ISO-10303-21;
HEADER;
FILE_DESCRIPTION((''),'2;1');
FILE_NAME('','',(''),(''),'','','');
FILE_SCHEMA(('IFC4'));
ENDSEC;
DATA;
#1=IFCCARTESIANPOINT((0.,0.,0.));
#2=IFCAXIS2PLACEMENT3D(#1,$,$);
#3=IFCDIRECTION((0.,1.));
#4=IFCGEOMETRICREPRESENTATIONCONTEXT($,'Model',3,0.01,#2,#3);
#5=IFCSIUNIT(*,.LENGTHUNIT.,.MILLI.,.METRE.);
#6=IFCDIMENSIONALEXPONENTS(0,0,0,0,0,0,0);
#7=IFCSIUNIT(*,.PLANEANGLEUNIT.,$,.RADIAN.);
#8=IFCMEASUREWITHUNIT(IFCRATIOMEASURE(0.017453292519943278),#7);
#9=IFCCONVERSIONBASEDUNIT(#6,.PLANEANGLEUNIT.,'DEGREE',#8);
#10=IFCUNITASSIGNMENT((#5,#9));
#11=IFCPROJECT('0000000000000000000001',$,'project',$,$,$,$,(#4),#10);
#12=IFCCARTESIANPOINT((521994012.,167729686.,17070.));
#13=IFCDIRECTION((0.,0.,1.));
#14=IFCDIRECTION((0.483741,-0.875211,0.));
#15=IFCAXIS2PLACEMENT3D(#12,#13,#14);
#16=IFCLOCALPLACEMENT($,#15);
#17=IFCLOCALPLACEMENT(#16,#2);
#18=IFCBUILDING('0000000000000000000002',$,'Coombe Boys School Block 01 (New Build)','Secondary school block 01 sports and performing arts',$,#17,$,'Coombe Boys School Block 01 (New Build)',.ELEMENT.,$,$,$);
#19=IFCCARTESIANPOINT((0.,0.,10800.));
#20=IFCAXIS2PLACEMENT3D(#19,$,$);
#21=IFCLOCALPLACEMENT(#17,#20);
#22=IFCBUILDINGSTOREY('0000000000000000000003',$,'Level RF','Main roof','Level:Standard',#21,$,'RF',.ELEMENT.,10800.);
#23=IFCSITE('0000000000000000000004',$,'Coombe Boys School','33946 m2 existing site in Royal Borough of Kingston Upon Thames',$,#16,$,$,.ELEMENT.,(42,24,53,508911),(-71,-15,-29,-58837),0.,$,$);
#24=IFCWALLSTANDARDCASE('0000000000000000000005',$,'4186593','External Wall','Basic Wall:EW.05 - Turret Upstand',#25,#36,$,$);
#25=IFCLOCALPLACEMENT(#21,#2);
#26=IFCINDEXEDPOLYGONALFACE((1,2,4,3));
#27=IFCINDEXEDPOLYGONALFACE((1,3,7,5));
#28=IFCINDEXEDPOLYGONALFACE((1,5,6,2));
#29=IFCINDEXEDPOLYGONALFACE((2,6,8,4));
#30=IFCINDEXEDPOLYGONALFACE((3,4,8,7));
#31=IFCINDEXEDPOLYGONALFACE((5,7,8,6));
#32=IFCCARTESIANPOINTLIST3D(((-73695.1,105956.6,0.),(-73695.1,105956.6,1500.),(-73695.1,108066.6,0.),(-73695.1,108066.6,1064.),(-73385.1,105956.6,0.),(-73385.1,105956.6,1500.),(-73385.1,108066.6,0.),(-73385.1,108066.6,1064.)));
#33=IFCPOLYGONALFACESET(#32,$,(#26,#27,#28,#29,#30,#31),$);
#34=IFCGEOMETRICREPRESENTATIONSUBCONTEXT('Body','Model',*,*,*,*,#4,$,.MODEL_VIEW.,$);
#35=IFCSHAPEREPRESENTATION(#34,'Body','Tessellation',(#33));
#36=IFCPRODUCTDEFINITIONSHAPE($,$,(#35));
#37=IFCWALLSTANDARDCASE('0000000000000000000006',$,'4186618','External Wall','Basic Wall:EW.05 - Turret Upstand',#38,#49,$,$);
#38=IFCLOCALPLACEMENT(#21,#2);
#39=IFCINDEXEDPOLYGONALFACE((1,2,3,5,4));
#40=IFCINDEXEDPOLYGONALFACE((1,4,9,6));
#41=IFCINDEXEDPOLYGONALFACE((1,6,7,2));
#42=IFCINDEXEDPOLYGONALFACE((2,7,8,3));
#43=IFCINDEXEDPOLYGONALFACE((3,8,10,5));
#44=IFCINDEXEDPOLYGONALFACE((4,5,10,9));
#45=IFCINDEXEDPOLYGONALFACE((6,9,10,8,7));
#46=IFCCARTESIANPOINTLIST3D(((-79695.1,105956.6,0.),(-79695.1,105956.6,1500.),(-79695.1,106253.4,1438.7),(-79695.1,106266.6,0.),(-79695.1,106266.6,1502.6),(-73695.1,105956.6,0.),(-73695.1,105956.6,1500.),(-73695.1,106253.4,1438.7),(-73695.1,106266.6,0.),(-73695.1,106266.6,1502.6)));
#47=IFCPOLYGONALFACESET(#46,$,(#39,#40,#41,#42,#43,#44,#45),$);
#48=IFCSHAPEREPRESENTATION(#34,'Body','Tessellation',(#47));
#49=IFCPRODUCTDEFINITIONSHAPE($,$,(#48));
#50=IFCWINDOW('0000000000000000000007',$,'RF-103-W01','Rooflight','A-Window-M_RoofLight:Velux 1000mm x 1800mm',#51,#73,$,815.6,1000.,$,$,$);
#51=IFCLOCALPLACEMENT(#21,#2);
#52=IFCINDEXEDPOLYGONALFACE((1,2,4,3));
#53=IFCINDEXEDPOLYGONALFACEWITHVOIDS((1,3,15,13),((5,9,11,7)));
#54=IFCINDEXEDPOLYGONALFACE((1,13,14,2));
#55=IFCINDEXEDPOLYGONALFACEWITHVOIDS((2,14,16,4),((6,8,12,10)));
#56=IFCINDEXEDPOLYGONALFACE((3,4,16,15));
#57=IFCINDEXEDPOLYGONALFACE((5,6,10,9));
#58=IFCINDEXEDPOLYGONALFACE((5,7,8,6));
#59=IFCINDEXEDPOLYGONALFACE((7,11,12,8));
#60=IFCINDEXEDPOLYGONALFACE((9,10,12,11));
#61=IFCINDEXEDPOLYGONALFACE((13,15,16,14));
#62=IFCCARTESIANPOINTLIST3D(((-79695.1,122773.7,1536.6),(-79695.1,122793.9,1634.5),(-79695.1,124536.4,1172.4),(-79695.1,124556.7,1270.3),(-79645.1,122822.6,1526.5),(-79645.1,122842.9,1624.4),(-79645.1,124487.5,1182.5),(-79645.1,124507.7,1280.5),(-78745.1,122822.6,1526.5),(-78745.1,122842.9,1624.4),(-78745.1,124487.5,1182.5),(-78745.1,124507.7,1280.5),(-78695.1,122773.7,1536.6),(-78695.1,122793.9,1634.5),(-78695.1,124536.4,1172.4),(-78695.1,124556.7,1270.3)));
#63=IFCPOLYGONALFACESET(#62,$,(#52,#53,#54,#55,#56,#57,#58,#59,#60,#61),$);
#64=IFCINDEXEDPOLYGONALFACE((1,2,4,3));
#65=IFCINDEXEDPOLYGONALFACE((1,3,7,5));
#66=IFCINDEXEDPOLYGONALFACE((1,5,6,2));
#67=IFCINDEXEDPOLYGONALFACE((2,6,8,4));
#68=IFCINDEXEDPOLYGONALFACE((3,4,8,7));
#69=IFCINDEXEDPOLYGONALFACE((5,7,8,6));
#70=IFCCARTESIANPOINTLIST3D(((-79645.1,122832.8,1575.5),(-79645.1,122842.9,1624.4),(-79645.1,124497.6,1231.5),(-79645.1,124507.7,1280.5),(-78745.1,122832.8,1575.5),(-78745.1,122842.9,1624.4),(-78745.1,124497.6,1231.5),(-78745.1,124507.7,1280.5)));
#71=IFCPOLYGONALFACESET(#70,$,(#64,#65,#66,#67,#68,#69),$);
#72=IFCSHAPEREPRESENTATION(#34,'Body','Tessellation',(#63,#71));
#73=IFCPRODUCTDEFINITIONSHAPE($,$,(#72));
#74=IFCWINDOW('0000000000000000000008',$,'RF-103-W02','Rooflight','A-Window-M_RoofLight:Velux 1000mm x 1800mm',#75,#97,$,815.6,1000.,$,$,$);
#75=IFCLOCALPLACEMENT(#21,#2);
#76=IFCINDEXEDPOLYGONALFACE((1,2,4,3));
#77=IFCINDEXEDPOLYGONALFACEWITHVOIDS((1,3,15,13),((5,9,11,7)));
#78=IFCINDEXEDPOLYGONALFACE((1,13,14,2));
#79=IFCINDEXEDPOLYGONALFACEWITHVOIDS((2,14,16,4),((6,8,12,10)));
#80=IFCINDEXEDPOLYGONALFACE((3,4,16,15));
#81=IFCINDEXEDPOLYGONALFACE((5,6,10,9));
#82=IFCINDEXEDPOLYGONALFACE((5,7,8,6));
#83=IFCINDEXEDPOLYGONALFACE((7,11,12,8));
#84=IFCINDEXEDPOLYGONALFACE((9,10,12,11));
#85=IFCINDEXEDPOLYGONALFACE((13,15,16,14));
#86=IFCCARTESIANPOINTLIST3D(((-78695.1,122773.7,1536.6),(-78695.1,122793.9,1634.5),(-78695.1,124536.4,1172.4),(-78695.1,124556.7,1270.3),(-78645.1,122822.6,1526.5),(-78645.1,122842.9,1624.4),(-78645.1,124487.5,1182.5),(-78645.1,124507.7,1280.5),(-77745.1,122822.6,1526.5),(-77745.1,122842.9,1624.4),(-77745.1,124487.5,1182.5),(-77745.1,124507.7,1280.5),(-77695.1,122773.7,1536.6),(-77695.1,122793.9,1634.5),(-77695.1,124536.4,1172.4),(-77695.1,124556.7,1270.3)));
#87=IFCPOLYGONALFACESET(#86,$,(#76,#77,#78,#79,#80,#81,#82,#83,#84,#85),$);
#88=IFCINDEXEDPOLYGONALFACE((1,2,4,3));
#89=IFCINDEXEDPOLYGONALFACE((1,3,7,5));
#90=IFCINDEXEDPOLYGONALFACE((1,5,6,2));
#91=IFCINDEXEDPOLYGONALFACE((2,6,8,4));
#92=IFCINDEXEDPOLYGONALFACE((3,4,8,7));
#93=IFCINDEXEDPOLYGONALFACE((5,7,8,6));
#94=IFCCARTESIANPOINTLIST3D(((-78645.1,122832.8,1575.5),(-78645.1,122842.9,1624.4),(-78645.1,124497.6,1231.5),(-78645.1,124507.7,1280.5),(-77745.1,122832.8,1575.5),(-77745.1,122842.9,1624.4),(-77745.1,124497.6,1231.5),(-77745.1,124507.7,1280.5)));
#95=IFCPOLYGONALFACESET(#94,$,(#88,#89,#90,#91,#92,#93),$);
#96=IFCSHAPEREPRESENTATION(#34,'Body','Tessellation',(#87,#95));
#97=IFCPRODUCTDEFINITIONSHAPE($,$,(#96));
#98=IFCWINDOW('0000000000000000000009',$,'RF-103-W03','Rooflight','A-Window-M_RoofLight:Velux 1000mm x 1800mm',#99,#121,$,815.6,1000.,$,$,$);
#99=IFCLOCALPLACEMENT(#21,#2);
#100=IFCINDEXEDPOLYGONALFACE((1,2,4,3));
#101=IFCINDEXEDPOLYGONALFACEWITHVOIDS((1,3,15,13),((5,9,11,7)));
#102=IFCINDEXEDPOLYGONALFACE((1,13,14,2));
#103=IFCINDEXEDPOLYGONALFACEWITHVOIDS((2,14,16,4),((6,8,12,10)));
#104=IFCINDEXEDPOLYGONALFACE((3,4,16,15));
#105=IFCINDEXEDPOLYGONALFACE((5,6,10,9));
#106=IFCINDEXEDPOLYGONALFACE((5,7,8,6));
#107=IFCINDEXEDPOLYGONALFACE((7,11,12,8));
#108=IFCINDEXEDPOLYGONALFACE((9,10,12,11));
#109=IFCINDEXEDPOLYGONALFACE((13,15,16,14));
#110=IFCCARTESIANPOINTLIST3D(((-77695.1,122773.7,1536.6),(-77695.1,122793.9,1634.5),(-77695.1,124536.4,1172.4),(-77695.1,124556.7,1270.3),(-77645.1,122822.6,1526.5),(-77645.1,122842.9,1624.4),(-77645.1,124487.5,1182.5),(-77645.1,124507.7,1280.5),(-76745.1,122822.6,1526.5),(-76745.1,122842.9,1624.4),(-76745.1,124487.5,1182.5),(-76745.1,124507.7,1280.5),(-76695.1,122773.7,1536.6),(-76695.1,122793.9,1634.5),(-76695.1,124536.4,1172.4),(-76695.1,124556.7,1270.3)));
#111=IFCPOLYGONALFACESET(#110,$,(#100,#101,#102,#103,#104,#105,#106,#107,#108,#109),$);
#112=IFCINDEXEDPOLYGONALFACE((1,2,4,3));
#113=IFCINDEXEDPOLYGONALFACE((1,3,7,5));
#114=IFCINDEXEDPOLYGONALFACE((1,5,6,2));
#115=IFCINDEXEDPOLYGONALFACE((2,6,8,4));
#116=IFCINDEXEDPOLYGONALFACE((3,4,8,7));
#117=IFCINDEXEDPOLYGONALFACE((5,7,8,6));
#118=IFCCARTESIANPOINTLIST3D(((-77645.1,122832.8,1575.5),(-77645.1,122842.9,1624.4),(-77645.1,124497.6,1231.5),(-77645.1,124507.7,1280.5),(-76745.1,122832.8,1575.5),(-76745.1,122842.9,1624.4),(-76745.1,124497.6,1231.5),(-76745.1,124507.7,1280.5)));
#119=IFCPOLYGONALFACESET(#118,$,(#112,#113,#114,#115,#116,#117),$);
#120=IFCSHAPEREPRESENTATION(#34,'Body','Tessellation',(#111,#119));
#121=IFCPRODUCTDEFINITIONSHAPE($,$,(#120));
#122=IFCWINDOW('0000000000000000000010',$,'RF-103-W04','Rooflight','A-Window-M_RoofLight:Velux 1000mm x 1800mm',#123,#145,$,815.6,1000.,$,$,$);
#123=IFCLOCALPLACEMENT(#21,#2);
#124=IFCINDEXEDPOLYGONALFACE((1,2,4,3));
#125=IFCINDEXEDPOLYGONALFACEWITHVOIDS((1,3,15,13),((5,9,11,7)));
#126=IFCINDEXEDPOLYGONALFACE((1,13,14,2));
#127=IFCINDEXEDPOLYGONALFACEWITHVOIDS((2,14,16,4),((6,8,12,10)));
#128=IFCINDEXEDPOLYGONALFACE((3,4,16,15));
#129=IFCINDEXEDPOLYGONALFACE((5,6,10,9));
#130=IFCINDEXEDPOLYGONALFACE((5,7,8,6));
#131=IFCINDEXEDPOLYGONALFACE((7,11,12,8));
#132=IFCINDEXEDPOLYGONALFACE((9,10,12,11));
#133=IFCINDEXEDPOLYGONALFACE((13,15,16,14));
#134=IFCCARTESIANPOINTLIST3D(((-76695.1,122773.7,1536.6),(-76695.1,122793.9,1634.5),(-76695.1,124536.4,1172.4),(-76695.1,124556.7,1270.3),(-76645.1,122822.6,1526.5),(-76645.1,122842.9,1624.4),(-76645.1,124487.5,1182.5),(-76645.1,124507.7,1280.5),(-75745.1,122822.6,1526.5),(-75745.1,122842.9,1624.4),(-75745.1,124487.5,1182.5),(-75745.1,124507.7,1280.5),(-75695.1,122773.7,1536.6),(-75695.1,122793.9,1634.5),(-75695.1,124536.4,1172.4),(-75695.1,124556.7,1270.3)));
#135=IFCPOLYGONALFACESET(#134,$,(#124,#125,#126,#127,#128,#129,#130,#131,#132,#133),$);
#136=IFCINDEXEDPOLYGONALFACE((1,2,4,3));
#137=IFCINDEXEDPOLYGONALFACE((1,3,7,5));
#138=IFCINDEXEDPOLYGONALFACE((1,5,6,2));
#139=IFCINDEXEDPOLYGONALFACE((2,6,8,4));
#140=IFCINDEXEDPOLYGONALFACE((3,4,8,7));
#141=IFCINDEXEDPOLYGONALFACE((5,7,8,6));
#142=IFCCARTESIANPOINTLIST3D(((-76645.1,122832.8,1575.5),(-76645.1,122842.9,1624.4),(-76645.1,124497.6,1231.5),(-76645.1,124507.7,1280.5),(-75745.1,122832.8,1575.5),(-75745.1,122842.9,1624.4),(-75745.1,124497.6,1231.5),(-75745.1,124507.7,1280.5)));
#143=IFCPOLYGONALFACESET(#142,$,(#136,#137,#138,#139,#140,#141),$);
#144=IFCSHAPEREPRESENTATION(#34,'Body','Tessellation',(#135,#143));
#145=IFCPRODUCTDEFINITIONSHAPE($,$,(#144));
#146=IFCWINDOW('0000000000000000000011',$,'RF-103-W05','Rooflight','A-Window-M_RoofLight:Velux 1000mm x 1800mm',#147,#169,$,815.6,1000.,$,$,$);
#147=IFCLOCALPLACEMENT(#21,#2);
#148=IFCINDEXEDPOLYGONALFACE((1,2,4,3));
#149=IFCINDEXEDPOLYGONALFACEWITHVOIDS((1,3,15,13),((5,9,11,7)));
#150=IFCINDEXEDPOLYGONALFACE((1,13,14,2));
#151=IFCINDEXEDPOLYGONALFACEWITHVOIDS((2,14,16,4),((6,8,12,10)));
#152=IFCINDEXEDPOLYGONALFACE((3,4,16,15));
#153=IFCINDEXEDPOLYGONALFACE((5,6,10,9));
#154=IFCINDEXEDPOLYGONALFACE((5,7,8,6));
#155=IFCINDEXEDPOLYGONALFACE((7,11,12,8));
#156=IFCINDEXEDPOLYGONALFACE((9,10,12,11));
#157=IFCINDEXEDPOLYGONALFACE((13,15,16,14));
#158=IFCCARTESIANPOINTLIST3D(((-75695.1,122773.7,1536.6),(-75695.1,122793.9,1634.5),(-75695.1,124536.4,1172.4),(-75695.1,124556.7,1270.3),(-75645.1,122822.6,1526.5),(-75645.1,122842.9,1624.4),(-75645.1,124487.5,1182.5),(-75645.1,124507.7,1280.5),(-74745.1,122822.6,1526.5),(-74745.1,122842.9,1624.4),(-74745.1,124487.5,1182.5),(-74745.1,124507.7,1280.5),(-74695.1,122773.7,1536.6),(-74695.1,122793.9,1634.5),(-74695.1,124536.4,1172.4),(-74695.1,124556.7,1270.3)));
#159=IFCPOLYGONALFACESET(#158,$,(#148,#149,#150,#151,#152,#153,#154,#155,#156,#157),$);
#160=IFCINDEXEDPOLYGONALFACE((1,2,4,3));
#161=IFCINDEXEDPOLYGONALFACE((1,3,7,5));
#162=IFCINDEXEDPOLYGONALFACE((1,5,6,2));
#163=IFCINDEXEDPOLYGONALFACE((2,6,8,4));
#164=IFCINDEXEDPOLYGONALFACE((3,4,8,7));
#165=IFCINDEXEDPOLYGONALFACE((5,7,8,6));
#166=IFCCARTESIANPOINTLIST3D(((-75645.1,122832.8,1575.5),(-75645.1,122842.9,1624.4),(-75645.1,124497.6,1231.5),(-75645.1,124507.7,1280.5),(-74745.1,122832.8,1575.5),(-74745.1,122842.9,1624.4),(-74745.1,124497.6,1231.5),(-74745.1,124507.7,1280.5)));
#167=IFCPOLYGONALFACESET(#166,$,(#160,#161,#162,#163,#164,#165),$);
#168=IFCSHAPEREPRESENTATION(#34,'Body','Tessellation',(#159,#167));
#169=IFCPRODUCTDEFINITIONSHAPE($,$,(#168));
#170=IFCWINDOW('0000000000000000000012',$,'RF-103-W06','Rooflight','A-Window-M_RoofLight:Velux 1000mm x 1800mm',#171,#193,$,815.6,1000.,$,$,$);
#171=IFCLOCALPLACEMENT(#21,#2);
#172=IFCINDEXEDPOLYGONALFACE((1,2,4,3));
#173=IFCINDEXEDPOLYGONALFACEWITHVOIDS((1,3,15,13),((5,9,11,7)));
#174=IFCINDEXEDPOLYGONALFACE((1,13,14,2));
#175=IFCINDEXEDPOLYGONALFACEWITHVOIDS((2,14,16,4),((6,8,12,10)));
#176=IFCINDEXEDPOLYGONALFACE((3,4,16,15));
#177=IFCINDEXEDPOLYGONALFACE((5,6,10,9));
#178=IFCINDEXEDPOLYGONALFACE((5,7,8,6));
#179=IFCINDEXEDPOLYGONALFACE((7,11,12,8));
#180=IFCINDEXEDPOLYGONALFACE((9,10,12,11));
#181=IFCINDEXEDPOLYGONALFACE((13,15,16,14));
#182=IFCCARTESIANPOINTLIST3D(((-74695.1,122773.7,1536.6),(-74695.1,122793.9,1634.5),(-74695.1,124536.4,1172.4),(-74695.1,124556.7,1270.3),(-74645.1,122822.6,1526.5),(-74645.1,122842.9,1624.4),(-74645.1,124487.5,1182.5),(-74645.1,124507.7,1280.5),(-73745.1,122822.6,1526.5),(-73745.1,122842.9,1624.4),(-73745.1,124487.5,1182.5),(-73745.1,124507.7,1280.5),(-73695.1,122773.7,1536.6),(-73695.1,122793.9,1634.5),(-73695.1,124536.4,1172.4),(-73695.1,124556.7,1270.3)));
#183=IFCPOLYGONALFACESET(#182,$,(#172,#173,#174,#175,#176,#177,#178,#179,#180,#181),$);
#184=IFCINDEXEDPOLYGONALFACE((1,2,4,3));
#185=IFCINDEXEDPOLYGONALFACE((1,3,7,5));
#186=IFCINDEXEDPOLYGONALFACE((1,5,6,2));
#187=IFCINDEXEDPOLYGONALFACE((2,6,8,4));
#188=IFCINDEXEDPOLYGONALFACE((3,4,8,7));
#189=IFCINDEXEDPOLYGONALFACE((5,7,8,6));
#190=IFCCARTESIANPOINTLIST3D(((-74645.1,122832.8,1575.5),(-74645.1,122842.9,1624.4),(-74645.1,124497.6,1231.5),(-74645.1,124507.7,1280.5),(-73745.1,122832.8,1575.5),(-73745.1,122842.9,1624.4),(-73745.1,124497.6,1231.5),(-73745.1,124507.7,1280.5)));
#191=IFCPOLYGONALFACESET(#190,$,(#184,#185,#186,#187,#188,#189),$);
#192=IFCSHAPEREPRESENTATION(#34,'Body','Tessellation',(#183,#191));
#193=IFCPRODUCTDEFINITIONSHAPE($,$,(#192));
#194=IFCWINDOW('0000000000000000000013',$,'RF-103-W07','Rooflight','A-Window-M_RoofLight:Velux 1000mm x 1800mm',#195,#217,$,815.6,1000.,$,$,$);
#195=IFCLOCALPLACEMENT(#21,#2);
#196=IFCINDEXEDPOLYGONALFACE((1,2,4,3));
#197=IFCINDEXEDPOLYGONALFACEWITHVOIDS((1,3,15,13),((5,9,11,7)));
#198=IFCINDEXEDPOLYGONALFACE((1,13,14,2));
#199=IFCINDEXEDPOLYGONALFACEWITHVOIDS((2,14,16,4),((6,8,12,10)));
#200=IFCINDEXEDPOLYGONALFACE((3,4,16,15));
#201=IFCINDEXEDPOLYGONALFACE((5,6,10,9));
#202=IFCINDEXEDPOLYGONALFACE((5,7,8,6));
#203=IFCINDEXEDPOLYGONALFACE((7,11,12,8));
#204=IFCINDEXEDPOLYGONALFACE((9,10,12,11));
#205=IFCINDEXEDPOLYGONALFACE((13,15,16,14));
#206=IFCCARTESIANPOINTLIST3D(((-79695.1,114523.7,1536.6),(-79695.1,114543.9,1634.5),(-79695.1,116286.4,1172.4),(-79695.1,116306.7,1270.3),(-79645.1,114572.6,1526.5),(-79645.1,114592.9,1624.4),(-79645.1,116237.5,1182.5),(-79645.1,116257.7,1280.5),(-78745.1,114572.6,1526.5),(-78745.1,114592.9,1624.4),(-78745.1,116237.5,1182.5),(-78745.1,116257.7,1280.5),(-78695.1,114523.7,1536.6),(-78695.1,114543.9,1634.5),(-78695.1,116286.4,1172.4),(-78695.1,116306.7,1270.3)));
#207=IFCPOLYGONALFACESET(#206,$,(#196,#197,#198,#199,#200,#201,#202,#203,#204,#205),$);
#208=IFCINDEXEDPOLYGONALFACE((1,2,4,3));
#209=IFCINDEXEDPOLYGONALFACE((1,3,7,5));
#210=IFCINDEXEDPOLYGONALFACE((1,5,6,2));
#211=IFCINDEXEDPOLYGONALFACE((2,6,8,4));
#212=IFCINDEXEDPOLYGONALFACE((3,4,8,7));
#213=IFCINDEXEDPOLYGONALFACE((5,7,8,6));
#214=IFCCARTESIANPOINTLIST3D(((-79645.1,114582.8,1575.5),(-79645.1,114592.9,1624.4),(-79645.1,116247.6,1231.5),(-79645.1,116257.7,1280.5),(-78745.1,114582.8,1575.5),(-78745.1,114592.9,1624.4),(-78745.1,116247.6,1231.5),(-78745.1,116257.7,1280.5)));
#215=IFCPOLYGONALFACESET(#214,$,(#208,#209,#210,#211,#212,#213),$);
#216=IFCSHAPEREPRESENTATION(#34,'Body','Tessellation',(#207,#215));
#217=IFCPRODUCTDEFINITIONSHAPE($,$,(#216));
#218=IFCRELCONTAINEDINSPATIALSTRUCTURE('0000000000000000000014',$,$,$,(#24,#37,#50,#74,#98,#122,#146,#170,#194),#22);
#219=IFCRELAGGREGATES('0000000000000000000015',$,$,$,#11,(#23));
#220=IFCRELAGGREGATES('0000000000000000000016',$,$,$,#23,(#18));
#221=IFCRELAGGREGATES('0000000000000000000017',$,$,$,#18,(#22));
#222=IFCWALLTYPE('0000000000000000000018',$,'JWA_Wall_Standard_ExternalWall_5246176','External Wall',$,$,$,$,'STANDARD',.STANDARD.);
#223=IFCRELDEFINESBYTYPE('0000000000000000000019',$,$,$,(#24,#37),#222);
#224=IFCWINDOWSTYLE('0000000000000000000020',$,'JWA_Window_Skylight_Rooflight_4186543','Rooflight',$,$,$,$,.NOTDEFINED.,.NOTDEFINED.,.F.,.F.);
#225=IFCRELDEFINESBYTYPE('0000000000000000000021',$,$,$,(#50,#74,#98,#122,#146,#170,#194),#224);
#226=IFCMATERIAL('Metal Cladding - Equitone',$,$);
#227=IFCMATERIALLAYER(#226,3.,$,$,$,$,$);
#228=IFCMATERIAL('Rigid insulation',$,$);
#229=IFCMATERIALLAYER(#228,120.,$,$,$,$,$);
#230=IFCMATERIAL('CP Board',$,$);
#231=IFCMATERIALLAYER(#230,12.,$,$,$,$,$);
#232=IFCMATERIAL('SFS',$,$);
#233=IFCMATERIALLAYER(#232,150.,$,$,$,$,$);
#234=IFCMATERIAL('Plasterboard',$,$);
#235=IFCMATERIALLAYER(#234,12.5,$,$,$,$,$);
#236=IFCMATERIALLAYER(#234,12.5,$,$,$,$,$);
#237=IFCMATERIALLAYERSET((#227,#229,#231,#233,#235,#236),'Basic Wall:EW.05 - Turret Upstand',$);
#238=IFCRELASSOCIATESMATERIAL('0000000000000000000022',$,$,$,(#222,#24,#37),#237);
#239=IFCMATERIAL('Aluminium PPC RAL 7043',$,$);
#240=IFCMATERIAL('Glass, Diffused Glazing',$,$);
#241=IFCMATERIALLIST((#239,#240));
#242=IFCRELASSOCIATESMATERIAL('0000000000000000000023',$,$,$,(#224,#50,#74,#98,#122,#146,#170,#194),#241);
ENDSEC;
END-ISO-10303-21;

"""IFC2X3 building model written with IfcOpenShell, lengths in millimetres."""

from ifc_helpers import new_model, entity, si_unit, converted_unit, direction, frame, frame_2d, origin, place, context, subcontext, project, spatial, polyline, rectangle, outline, extrude, clip, bounded_halfspace, source, transform, mapped, material, material_list, layer, layer_set, layer_usage, type_object, type_shapes, element, save


model = new_model("IFC2X3")

# Units and contexts
model_context = context("Model", 3, precision=0.01, world=origin(), true_north=direction((0.0, 1.0)))
body_context = subcontext(model_context, "Body", "Model", "MODEL_VIEW")
ifc_project = project(units=[si_unit("LENGTHUNIT", "METRE", prefix="MILLI"), converted_unit("PLANEANGLEUNIT", "DEGREE", entity("IfcRatioMeasure", 0.017453292519943278), si_unit("PLANEANGLEUNIT", "RADIAN"), dimensions=[0, 0, 0, 0, 0, 0, 0])], contexts=[model_context])

# Site, building, storey
site_placement = place(None, frame((521994012.0, 167729686.0, 17070.0), z_axis=(0.0, 0.0, 1.0), x_axis=(0.483741, -0.875211, 0.0)))
site = spatial("IfcSite", under=ifc_project, at=site_placement, Name="Coombe Boys School", Description="33946 m2 existing site in Royal Borough of Kingston Upon Thames", CompositionType="ELEMENT", RefLatitude=(42, 24, 53, 508911), RefLongitude=(-71, -15, -29, -58837), RefElevation=0.0)
building_placement = place(site_placement, origin())
building = spatial("IfcBuilding", under=site, at=building_placement, Name="Coombe Boys School Block 01 (New Build)", Description="Secondary school block 01 sports and performing arts", LongName="Coombe Boys School Block 01 (New Build)", CompositionType="ELEMENT")
storey_placement = place(building_placement, frame((0.0, 0.0, 10800.0)))
storey = spatial("IfcBuildingStorey", under=building, at=storey_placement, Name="Level RF", Description="Main roof", ObjectType="Level:Standard", LongName="RF", CompositionType="ELEMENT", Elevation=10800.0)

# Walls
ifc_material_1 = material(Name="Metal Cladding - Equitone")
ifc_layer_1 = layer(ifc_material_1, 3.0)
ifc_material_2 = material(Name="Rigid insulation")
ifc_layer_2 = layer(ifc_material_2, 120.0)
ifc_material_3 = material(Name="CP Board")
ifc_layer_3 = layer(ifc_material_3, 12.0)
ifc_material_4 = material(Name="SFS")
ifc_layer_4 = layer(ifc_material_4, 150.0)
ifc_material_5 = material(Name="Plasterboard")
ifc_layer_5 = layer(ifc_material_5, 12.5)
ifc_layer_6 = layer(ifc_material_5, 12.5)
ifc_layer_set_1 = layer_set([ifc_layer_1, ifc_layer_2, ifc_layer_3, ifc_layer_4, ifc_layer_5, ifc_layer_6], Name="Basic Wall:EW.05 - Turret Upstand")
ifc_layer_usage_1 = layer_usage(ifc_layer_set_1, "AXIS2", "POSITIVE", -155.0)
wall_type_1 = type_object("IfcWallType", Name="JWA_Wall_Standard_ExternalWall_5246176", Description="External Wall", ElementType="STANDARD", PredefinedType="STANDARD", material=ifc_layer_set_1)
ifc_layer_usage_2 = layer_usage(ifc_layer_set_1, "AXIS2", "NEGATIVE", 155.0)
wall_1_placement = place(storey_placement, frame((-73540.1, 105956.6, 0.0), z_axis=(0.0, 0.0, 1.0), x_axis=(0.0, 1.0, 0.0)))
element("IfcWallStandardCase", 1, at=wall_1_placement, inside=storey, type_object=wall_type_1, material=ifc_layer_usage_1, Name="4186593", Description="External Wall", ObjectType="Basic Wall:EW.05 - Turret Upstand", context=body_context, shape_type="Clipping", body=[
    clip(extrude(rectangle(XDim=2110.0, YDim=310.0, at=frame_2d((1055.0, 0.0), x_axis=(-1.0, 0.0))), origin(), (0.0, 0.0, 1.0), 1500.0), bounded_halfspace(frame((0.0, -155.0, 1500.0), z_axis=(0.202338, 0.0, 0.979316), x_axis=(0.0, 1.0, 0.0)), False, frame((0.0, -155.0, 1500.0)), polyline([(0.0, 0.0), (2110.0, 0.0), (2110.0, 310.0), (2059.6, 310.0), (296.8, 310.0), (0.0, 310.0), (0.0, 0.0)]))),
])
wall_2_placement = place(storey_placement, frame((-73695.1, 106111.6, 0.0), z_axis=(0.0, 0.0, 1.0), x_axis=(-1.0, 0.0, 0.0)))
element("IfcWallStandardCase", 2, at=wall_2_placement, inside=storey, type_object=wall_type_1, material=ifc_layer_usage_2, Name="4186618", Description="External Wall", ObjectType="Basic Wall:EW.05 - Turret Upstand", context=body_context, shape_type="Clipping", body=[
    clip(clip(extrude(rectangle(XDim=6000.0, YDim=310.0, at=frame_2d((3000.0, 0.0), x_axis=(-1.0, 0.0))), origin(), (0.0, 0.0, 1.0), 1502.6), bounded_halfspace(frame((0.0, -155.0, 1502.6), z_axis=(0.0, 0.979316, 0.202338), x_axis=(0.0, -0.202338, 0.979316)), False, frame((0.0, -155.0, 1502.6)), polyline([(0.0, 0.0), (6000.0, 0.0), (6000.0, 13.2), (0.0, 13.2), (0.0, 0.0)]))), bounded_halfspace(frame((6000.0, -141.8, 1438.7), z_axis=(0.0, -0.202338, 0.979316), x_axis=(1.0, 0.0, 0.0)), False, frame((6000.0, -141.8, 1438.7)), polyline([(0.0, 0.0), (0.0, 296.8), (-6000.0, 296.8), (-6000.0, 0.0), (0.0, 0.0)]))),
])

# Windows
ifc_material_6 = material(Name="Aluminium PPC RAL 7043")
ifc_material_7 = material(Name="Glass, Diffused Glazing")
ifc_material_list = material_list([ifc_material_6, ifc_material_7])
window_style = type_object("IfcWindowStyle", Name="JWA_Window_Skylight_Rooflight_4186543", Description="Rooflight", ConstructionType="NOTDEFINED", OperationType="NOTDEFINED", ParameterTakesPrecedence=False, Sizeable=False, material=ifc_material_list)
shared_shape_1 = source(origin(), body_context, "Body", "SweptSolid", [
    extrude(outline(polyline([(-500.0, -900.0), (500.0, -900.0), (500.0, 900.0), (-500.0, 900.0), (-500.0, -900.0)]), holes=[polyline([(-450.0, -850.0), (-450.0, 850.0), (450.0, 850.0), (450.0, -850.0), (-450.0, -850.0)])]), frame((0.0, 0.0, 4100.0), z_axis=(0.0, 0.0, 1.0), x_axis=(-1.0, 0.0, 0.0)), (0.0, 0.0, 1.0), 100.0),
    extrude(rectangle(XDim=900.0, YDim=1700.0, at=frame_2d((0.0, 0.0), x_axis=(1.0, 0.0))), frame((0.0, 0.0, 4150.0), z_axis=(0.0, 0.0, 1.0), x_axis=(-1.0, 0.0, 0.0)), (0.0, 0.0, 1.0), 50.0),
])
type_shapes(window_style, [shared_shape_1])
for number, where, z_axis, x_axis, name in (
    (3, (-79195.1, 122825.5, -2660.7), (0.0, 0.202338, 0.979316), (-1.0, 0.0, 0.0), "RF-103-W01"),
    (4, (-78195.1, 122825.5, -2660.7), (0.0, 0.202338, 0.979316), (-1.0, 0.0, 0.0), "RF-103-W02"),
    (5, (-77195.1, 122825.5, -2660.7), (0.0, 0.202338, 0.979316), (-1.0, 0.0, 0.0), "RF-103-W03"),
    (6, (-76195.1, 122825.5, -2660.7), (0.0, 0.202338, 0.979316), (-1.0, 0.0, 0.0), "RF-103-W04"),
    (7, (-75195.1, 122825.5, -2660.7), (0.0, 0.202338, 0.979316), (-1.0, 0.0, 0.0), "RF-103-W05"),
    (8, (-74195.1, 122825.5, -2660.7), (0.0, 0.202338, 0.979316), (-1.0, 0.0, 0.0), "RF-103-W06"),
    (9, (-79195.1, 114575.5, -2660.7), (0.0, 0.202338, 0.979316), (-1.0, 0.0, 0.0), "RF-103-W07"),
):
    element("IfcWindow", number, at=place(storey_placement, frame(where, z_axis=z_axis, x_axis=x_axis)), inside=storey, type_object=window_style, material=ifc_material_list, Name=name, Description="Rooflight", ObjectType="A-Window-M_RoofLight:Velux 1000mm x 1800mm", OverallHeight=815.6, OverallWidth=1000.0, context=body_context, shape_type="MappedRepresentation", body=[
        mapped(shared_shape_1, transform((0.0, 0.0, 0.0), scale=1.0)),
    ])

save(model, "model.ifc")
